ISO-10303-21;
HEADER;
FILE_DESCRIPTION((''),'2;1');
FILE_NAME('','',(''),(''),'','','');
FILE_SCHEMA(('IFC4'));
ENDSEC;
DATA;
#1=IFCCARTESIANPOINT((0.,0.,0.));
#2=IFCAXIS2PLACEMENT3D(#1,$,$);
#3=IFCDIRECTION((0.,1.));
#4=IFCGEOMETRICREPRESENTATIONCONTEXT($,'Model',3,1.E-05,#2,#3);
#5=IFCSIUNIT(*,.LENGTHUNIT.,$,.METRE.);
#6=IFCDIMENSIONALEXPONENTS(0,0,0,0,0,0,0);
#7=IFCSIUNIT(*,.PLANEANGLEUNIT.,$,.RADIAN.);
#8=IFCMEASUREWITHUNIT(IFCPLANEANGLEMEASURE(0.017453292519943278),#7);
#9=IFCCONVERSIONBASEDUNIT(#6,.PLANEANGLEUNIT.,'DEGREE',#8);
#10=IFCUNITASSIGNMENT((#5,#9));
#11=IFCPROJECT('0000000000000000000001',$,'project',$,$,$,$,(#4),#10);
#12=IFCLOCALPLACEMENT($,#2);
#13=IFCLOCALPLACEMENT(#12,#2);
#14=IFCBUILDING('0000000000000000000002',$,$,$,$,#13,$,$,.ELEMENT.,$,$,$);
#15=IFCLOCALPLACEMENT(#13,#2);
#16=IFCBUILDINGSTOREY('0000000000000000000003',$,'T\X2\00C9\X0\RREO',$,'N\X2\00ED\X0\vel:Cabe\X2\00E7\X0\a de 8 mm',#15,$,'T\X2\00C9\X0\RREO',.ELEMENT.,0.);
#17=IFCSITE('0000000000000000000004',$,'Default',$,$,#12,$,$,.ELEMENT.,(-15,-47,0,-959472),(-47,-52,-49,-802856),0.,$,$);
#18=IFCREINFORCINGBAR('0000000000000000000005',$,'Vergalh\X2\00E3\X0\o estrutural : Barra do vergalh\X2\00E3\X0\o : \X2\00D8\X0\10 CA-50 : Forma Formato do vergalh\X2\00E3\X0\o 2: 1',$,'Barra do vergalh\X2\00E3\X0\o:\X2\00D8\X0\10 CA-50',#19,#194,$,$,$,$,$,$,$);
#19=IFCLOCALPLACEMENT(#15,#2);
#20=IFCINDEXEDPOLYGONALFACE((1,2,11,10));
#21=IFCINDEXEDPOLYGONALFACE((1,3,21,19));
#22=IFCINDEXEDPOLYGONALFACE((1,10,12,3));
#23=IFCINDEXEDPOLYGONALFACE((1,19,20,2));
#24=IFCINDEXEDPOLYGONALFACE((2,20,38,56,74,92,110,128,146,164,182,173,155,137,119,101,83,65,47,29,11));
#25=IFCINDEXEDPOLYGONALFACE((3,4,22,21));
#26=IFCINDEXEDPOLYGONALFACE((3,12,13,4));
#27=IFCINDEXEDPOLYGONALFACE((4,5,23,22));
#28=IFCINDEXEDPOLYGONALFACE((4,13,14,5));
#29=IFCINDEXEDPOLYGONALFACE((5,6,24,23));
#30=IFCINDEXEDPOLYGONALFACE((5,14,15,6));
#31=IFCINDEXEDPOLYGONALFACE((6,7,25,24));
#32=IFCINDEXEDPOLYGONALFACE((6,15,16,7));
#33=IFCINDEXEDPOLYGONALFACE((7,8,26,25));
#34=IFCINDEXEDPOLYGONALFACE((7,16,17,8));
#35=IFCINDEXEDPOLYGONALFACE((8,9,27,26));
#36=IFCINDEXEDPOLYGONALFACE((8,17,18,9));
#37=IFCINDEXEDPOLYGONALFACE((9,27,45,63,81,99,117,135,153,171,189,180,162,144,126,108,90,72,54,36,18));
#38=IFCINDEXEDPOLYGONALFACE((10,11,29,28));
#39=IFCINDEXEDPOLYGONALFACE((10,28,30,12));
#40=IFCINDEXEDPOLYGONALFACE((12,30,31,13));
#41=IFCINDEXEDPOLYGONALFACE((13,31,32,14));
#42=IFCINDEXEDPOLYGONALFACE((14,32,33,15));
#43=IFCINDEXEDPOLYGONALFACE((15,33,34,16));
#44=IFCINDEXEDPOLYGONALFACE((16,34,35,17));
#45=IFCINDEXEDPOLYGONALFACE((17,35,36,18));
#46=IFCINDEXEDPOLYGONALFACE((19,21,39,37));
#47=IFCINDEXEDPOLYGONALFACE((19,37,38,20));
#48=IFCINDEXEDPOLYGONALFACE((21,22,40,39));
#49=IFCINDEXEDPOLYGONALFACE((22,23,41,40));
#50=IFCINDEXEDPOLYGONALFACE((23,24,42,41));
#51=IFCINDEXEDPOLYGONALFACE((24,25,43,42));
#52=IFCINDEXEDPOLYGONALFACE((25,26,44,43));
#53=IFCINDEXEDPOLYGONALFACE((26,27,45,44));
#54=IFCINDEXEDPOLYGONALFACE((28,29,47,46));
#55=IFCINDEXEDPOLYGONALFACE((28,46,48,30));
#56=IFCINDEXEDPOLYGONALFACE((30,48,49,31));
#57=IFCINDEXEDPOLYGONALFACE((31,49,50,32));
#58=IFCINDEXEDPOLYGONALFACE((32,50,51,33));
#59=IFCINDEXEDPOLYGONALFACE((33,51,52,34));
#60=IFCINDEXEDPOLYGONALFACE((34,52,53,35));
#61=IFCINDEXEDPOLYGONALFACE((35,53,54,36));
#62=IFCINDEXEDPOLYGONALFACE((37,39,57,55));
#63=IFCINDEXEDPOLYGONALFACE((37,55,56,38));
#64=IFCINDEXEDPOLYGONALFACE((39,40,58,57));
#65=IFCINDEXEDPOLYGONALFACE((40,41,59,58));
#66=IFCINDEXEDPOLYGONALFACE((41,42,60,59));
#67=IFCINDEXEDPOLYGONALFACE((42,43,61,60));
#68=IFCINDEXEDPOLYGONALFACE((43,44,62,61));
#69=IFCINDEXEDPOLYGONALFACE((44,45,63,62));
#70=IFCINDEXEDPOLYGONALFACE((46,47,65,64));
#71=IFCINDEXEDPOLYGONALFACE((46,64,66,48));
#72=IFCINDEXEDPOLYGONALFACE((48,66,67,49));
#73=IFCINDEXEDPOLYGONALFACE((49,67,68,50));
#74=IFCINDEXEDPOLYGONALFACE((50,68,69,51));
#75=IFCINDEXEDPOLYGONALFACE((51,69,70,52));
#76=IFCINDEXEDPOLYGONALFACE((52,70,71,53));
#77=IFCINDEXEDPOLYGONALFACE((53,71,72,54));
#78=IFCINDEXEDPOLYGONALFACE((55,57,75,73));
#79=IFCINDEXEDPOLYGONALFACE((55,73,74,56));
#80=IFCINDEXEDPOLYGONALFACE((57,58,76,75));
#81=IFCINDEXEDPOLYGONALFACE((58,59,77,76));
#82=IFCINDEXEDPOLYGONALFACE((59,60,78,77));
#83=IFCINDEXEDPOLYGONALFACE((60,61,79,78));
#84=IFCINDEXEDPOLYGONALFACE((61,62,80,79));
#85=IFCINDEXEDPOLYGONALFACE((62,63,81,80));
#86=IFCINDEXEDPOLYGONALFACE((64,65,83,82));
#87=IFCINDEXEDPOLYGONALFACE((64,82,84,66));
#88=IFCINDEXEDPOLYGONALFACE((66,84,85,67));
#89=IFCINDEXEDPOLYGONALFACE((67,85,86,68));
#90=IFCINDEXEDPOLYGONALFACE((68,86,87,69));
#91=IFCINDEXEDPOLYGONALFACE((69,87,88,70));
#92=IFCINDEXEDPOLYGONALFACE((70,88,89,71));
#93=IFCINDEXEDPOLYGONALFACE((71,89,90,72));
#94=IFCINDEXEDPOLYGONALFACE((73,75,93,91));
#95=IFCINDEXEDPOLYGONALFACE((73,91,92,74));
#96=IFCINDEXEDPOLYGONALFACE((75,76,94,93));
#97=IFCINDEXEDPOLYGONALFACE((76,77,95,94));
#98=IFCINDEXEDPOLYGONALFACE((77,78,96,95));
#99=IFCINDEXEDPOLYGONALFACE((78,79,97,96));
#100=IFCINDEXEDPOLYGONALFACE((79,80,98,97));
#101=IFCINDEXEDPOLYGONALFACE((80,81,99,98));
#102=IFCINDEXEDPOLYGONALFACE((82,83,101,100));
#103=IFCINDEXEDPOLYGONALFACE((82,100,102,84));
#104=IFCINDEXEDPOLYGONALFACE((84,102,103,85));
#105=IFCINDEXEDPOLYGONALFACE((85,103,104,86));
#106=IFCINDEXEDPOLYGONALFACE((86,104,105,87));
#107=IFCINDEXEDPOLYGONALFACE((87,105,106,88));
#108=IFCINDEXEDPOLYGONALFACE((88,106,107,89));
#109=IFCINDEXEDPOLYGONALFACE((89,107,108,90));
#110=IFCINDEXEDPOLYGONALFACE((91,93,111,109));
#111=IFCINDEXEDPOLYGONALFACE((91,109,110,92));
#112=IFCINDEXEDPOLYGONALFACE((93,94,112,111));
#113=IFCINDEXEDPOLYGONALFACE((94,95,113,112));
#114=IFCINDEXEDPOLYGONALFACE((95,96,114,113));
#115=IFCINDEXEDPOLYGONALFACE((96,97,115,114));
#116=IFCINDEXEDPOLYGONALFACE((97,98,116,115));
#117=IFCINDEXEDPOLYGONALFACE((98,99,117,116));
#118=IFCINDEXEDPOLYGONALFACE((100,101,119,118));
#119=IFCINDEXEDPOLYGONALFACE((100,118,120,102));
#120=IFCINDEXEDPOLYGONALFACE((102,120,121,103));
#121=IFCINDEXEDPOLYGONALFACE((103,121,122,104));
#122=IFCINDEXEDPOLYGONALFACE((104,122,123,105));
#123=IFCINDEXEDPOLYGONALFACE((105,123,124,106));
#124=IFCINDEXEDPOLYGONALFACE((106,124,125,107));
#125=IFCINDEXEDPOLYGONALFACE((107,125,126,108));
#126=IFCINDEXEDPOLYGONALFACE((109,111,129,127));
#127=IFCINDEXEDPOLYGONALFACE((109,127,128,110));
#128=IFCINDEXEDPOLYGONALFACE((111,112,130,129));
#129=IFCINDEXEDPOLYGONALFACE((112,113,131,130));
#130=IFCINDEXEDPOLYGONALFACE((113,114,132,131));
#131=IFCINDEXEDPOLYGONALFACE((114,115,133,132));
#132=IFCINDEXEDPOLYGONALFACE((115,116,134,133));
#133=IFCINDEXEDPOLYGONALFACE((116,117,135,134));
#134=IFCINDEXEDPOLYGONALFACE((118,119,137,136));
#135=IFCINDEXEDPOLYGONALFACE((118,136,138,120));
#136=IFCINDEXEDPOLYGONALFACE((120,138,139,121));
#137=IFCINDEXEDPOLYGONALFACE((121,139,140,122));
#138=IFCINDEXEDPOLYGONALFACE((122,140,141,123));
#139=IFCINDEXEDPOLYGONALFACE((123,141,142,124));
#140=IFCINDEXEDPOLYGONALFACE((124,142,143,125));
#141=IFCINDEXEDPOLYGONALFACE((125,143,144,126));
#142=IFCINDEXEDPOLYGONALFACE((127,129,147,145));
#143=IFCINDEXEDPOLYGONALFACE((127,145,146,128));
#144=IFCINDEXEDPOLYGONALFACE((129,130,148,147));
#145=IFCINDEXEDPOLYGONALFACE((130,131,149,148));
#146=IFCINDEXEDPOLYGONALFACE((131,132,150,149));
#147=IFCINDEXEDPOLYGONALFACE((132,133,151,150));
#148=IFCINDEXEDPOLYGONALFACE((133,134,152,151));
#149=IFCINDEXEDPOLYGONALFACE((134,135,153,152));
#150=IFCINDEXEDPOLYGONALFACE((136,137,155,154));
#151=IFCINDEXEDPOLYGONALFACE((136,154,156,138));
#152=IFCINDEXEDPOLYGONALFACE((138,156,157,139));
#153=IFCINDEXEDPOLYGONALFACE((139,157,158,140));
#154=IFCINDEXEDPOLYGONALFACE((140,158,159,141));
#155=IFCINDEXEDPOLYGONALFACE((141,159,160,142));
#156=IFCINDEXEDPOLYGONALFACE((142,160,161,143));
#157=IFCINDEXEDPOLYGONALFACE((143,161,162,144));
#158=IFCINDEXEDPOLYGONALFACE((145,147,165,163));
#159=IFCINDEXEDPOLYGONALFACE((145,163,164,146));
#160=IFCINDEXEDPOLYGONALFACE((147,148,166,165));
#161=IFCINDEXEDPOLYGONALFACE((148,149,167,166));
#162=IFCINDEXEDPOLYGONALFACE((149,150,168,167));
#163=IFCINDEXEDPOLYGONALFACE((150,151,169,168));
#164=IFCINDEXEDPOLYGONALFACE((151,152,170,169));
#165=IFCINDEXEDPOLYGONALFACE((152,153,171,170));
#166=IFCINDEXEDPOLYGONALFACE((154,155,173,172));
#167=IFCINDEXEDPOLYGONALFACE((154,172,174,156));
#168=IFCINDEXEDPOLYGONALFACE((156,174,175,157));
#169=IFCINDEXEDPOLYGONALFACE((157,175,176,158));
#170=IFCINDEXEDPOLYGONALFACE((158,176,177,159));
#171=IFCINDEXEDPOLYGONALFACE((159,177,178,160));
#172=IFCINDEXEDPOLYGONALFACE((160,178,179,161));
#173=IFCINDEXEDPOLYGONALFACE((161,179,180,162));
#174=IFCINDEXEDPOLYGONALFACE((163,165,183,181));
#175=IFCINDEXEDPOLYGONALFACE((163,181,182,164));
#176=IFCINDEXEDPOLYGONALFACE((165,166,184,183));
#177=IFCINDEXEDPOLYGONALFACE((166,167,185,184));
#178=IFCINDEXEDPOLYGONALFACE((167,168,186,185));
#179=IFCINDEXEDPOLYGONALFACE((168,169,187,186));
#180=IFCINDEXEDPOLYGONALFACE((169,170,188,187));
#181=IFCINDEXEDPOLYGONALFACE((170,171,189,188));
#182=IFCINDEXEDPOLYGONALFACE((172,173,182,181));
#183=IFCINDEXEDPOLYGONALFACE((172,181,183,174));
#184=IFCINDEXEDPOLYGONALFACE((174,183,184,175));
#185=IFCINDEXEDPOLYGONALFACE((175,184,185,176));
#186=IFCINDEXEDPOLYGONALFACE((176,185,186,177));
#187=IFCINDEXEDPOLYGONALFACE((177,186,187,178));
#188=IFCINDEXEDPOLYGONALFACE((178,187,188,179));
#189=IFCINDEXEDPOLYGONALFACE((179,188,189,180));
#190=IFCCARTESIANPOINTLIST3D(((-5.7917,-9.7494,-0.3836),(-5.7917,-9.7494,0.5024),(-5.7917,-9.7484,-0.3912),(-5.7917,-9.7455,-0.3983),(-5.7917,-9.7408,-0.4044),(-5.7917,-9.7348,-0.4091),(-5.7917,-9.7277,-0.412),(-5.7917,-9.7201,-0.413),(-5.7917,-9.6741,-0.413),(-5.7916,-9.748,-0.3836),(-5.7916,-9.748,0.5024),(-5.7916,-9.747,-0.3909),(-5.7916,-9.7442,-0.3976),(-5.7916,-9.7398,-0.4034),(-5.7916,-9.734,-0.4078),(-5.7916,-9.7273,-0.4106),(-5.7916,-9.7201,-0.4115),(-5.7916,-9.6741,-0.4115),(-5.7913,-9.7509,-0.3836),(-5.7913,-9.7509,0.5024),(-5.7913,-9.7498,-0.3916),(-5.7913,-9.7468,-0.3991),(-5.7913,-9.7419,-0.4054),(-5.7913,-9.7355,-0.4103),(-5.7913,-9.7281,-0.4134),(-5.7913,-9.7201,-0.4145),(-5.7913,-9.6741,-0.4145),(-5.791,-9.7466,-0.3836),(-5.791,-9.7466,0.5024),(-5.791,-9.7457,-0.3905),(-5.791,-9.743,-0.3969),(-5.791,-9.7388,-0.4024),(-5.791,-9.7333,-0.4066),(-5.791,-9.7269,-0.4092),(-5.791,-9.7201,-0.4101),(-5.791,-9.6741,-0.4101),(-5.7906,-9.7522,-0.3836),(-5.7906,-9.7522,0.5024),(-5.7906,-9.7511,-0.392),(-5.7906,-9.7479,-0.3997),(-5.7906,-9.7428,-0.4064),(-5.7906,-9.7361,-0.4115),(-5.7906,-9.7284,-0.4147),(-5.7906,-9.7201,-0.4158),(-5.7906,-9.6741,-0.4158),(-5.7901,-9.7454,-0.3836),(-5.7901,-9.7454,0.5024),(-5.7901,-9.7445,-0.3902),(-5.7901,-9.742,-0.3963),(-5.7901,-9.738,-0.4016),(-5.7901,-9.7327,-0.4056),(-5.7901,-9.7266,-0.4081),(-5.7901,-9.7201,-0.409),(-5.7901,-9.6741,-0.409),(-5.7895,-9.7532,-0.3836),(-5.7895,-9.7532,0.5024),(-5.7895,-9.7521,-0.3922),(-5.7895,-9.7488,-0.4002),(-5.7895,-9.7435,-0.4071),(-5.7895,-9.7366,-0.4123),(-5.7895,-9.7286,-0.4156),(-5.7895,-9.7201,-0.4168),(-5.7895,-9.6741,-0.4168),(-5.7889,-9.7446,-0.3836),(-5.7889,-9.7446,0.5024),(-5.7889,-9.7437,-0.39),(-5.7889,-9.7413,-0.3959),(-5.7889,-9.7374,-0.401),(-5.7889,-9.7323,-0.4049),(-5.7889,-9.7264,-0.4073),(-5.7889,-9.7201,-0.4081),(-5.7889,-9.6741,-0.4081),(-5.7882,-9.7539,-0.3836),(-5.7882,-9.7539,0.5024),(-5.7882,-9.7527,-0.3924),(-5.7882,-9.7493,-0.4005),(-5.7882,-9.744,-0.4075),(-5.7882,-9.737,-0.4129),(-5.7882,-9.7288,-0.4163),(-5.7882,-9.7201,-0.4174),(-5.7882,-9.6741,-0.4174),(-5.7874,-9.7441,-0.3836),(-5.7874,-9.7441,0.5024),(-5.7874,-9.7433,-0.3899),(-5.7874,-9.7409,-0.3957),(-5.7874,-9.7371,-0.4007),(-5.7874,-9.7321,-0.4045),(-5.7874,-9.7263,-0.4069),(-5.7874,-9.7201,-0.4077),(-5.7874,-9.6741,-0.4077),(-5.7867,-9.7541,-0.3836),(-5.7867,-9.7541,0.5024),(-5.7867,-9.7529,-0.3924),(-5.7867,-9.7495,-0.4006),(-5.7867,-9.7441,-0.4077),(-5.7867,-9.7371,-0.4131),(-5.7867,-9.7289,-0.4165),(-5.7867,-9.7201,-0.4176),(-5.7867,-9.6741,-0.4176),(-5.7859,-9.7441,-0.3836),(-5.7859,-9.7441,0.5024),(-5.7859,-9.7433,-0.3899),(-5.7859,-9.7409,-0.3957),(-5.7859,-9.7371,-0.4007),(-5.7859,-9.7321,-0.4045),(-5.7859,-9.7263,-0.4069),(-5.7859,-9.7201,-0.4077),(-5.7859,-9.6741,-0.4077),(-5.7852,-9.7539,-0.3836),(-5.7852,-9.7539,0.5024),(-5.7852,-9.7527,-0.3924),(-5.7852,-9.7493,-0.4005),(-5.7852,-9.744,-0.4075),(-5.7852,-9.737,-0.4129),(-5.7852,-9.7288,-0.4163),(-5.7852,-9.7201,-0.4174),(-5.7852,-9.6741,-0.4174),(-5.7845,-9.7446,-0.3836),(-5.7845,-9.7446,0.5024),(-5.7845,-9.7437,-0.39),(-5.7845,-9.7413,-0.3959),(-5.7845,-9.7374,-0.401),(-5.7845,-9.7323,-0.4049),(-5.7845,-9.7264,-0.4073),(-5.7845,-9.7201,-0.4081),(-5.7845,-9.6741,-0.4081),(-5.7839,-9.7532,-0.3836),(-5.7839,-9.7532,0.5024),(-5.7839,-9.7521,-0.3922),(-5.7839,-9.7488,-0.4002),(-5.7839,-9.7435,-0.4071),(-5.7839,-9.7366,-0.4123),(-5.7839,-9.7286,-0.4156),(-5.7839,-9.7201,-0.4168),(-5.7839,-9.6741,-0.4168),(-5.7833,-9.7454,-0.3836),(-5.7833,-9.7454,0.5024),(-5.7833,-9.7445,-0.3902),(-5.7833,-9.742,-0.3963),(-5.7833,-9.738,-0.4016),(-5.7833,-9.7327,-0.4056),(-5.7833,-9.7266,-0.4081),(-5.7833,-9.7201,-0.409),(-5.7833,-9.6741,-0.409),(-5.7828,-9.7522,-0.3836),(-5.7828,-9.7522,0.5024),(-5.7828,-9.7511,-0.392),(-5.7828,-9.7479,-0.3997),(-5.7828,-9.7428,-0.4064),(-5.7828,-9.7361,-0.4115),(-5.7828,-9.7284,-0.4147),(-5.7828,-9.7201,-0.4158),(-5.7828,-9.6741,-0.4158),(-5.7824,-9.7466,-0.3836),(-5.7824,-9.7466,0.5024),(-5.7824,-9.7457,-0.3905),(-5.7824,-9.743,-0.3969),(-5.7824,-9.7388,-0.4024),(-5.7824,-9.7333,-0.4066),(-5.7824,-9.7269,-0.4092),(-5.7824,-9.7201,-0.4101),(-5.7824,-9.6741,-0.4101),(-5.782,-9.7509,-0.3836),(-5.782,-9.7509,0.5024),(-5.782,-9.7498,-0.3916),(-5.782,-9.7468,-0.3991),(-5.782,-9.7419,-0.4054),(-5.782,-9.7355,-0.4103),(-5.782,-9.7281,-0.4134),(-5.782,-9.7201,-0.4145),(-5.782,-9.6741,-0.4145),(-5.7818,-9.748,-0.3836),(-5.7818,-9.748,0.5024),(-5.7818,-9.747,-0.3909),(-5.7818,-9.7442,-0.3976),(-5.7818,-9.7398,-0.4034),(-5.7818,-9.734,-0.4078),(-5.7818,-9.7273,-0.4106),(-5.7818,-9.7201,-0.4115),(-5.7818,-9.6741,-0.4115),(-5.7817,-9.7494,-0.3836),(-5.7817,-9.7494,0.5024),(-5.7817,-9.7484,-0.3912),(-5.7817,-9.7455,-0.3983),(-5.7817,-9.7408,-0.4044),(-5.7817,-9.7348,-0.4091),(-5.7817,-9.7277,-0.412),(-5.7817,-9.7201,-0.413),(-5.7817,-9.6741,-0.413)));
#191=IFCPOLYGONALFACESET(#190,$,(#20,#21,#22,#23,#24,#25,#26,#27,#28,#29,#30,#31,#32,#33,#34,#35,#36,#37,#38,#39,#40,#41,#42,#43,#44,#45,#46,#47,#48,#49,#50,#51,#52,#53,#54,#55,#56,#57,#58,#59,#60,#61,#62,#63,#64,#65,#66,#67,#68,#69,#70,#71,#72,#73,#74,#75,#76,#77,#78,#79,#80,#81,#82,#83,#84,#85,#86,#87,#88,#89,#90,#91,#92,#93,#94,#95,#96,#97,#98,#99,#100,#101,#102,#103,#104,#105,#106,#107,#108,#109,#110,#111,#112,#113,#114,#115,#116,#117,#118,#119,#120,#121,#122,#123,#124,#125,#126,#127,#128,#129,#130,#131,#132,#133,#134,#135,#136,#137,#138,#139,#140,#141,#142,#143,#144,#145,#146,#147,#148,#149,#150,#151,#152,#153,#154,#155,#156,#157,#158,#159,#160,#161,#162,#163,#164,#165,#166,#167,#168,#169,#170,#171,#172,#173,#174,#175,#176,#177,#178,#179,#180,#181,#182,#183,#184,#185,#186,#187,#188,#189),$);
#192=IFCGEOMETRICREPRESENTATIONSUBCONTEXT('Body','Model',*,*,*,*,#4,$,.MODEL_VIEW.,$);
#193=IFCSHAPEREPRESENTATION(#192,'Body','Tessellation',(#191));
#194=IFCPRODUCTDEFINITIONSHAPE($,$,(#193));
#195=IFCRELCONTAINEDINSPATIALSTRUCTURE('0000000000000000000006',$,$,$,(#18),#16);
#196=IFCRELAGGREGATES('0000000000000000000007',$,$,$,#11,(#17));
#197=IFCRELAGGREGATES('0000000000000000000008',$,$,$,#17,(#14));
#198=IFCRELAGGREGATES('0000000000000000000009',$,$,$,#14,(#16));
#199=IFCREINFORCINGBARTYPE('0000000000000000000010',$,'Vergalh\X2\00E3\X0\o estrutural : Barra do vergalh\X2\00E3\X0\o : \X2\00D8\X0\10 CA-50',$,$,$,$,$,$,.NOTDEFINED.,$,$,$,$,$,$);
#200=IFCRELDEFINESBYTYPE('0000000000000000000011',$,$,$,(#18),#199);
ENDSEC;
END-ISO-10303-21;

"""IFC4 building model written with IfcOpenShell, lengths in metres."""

from ifc_helpers import new_model, entity, si_unit, converted_unit, direction, origin, place, context, subcontext, project, spatial, type_object, element, save


model = new_model("IFC4")

# Units and contexts
model_context = context("Model", 3, precision=1e-05, world=origin(), true_north=direction((0.0, 1.0)))
body_context = subcontext(model_context, "Body", "Model", "MODEL_VIEW")
ifc_project = project(units=[si_unit("LENGTHUNIT", "METRE"), converted_unit("PLANEANGLEUNIT", "DEGREE", entity("IfcPlaneAngleMeasure", 0.017453292519943278), si_unit("PLANEANGLEUNIT", "RADIAN"), dimensions=[0, 0, 0, 0, 0, 0, 0])], contexts=[model_context])

# Site, building, storey
site_placement = place(None, origin())
site = spatial("IfcSite", under=ifc_project, at=site_placement, Name="Default", CompositionType="ELEMENT", RefLatitude=(-15, -47, 0, -959472), RefLongitude=(-47, -52, -49, -802856), RefElevation=0.0)
building_placement = place(site_placement, origin())
building = spatial("IfcBuilding", under=site, at=building_placement, CompositionType="ELEMENT")
storey_placement = place(building_placement, origin())
storey = spatial("IfcBuildingStorey", under=building, at=storey_placement, Name="TÉRREO", ObjectType="Nível:Cabeça de 8 mm", LongName="TÉRREO", CompositionType="ELEMENT", Elevation=0.0)

# Reinforcing bar
reinforcing_bar_type_1 = type_object("IfcReinforcingBarType", Name="Vergalhão estrutural : Barra do vergalhão : Ø10 CA-50", PredefinedType="NOTDEFINED")
reinforcing_bar_1_placement = place(storey_placement, origin())
element("IfcReinforcingBar", 1, at=reinforcing_bar_1_placement, inside=storey, type_object=reinforcing_bar_type_1, Name="Vergalhão estrutural : Barra do vergalhão : Ø10 CA-50 : Forma Formato do vergalhão 2: 1", ObjectType="Barra do vergalhão:Ø10 CA-50", context=body_context, shape_type="AdvancedSweptSolid", body=[
    entity("IfcSweptDiskSolid", entity("IfcIndexedPolyCurve", entity("IfcCartesianPointList3D", [[-5.7867, -9.6741, -0.4126], [-5.7867, -9.7201, -0.4126], [-5.7867, -9.7406, -0.4042], [-5.7867, -9.7491, -0.3836], [-5.7867, -9.7491, 0.5024]]), [entity("IfcLineIndex", [1, 2]), entity("IfcArcIndex", [2, 3, 4]), entity("IfcLineIndex", [4, 5])], False), 0.005, None, 0.0, 92.0),
])

save(model, "model.ifc")
